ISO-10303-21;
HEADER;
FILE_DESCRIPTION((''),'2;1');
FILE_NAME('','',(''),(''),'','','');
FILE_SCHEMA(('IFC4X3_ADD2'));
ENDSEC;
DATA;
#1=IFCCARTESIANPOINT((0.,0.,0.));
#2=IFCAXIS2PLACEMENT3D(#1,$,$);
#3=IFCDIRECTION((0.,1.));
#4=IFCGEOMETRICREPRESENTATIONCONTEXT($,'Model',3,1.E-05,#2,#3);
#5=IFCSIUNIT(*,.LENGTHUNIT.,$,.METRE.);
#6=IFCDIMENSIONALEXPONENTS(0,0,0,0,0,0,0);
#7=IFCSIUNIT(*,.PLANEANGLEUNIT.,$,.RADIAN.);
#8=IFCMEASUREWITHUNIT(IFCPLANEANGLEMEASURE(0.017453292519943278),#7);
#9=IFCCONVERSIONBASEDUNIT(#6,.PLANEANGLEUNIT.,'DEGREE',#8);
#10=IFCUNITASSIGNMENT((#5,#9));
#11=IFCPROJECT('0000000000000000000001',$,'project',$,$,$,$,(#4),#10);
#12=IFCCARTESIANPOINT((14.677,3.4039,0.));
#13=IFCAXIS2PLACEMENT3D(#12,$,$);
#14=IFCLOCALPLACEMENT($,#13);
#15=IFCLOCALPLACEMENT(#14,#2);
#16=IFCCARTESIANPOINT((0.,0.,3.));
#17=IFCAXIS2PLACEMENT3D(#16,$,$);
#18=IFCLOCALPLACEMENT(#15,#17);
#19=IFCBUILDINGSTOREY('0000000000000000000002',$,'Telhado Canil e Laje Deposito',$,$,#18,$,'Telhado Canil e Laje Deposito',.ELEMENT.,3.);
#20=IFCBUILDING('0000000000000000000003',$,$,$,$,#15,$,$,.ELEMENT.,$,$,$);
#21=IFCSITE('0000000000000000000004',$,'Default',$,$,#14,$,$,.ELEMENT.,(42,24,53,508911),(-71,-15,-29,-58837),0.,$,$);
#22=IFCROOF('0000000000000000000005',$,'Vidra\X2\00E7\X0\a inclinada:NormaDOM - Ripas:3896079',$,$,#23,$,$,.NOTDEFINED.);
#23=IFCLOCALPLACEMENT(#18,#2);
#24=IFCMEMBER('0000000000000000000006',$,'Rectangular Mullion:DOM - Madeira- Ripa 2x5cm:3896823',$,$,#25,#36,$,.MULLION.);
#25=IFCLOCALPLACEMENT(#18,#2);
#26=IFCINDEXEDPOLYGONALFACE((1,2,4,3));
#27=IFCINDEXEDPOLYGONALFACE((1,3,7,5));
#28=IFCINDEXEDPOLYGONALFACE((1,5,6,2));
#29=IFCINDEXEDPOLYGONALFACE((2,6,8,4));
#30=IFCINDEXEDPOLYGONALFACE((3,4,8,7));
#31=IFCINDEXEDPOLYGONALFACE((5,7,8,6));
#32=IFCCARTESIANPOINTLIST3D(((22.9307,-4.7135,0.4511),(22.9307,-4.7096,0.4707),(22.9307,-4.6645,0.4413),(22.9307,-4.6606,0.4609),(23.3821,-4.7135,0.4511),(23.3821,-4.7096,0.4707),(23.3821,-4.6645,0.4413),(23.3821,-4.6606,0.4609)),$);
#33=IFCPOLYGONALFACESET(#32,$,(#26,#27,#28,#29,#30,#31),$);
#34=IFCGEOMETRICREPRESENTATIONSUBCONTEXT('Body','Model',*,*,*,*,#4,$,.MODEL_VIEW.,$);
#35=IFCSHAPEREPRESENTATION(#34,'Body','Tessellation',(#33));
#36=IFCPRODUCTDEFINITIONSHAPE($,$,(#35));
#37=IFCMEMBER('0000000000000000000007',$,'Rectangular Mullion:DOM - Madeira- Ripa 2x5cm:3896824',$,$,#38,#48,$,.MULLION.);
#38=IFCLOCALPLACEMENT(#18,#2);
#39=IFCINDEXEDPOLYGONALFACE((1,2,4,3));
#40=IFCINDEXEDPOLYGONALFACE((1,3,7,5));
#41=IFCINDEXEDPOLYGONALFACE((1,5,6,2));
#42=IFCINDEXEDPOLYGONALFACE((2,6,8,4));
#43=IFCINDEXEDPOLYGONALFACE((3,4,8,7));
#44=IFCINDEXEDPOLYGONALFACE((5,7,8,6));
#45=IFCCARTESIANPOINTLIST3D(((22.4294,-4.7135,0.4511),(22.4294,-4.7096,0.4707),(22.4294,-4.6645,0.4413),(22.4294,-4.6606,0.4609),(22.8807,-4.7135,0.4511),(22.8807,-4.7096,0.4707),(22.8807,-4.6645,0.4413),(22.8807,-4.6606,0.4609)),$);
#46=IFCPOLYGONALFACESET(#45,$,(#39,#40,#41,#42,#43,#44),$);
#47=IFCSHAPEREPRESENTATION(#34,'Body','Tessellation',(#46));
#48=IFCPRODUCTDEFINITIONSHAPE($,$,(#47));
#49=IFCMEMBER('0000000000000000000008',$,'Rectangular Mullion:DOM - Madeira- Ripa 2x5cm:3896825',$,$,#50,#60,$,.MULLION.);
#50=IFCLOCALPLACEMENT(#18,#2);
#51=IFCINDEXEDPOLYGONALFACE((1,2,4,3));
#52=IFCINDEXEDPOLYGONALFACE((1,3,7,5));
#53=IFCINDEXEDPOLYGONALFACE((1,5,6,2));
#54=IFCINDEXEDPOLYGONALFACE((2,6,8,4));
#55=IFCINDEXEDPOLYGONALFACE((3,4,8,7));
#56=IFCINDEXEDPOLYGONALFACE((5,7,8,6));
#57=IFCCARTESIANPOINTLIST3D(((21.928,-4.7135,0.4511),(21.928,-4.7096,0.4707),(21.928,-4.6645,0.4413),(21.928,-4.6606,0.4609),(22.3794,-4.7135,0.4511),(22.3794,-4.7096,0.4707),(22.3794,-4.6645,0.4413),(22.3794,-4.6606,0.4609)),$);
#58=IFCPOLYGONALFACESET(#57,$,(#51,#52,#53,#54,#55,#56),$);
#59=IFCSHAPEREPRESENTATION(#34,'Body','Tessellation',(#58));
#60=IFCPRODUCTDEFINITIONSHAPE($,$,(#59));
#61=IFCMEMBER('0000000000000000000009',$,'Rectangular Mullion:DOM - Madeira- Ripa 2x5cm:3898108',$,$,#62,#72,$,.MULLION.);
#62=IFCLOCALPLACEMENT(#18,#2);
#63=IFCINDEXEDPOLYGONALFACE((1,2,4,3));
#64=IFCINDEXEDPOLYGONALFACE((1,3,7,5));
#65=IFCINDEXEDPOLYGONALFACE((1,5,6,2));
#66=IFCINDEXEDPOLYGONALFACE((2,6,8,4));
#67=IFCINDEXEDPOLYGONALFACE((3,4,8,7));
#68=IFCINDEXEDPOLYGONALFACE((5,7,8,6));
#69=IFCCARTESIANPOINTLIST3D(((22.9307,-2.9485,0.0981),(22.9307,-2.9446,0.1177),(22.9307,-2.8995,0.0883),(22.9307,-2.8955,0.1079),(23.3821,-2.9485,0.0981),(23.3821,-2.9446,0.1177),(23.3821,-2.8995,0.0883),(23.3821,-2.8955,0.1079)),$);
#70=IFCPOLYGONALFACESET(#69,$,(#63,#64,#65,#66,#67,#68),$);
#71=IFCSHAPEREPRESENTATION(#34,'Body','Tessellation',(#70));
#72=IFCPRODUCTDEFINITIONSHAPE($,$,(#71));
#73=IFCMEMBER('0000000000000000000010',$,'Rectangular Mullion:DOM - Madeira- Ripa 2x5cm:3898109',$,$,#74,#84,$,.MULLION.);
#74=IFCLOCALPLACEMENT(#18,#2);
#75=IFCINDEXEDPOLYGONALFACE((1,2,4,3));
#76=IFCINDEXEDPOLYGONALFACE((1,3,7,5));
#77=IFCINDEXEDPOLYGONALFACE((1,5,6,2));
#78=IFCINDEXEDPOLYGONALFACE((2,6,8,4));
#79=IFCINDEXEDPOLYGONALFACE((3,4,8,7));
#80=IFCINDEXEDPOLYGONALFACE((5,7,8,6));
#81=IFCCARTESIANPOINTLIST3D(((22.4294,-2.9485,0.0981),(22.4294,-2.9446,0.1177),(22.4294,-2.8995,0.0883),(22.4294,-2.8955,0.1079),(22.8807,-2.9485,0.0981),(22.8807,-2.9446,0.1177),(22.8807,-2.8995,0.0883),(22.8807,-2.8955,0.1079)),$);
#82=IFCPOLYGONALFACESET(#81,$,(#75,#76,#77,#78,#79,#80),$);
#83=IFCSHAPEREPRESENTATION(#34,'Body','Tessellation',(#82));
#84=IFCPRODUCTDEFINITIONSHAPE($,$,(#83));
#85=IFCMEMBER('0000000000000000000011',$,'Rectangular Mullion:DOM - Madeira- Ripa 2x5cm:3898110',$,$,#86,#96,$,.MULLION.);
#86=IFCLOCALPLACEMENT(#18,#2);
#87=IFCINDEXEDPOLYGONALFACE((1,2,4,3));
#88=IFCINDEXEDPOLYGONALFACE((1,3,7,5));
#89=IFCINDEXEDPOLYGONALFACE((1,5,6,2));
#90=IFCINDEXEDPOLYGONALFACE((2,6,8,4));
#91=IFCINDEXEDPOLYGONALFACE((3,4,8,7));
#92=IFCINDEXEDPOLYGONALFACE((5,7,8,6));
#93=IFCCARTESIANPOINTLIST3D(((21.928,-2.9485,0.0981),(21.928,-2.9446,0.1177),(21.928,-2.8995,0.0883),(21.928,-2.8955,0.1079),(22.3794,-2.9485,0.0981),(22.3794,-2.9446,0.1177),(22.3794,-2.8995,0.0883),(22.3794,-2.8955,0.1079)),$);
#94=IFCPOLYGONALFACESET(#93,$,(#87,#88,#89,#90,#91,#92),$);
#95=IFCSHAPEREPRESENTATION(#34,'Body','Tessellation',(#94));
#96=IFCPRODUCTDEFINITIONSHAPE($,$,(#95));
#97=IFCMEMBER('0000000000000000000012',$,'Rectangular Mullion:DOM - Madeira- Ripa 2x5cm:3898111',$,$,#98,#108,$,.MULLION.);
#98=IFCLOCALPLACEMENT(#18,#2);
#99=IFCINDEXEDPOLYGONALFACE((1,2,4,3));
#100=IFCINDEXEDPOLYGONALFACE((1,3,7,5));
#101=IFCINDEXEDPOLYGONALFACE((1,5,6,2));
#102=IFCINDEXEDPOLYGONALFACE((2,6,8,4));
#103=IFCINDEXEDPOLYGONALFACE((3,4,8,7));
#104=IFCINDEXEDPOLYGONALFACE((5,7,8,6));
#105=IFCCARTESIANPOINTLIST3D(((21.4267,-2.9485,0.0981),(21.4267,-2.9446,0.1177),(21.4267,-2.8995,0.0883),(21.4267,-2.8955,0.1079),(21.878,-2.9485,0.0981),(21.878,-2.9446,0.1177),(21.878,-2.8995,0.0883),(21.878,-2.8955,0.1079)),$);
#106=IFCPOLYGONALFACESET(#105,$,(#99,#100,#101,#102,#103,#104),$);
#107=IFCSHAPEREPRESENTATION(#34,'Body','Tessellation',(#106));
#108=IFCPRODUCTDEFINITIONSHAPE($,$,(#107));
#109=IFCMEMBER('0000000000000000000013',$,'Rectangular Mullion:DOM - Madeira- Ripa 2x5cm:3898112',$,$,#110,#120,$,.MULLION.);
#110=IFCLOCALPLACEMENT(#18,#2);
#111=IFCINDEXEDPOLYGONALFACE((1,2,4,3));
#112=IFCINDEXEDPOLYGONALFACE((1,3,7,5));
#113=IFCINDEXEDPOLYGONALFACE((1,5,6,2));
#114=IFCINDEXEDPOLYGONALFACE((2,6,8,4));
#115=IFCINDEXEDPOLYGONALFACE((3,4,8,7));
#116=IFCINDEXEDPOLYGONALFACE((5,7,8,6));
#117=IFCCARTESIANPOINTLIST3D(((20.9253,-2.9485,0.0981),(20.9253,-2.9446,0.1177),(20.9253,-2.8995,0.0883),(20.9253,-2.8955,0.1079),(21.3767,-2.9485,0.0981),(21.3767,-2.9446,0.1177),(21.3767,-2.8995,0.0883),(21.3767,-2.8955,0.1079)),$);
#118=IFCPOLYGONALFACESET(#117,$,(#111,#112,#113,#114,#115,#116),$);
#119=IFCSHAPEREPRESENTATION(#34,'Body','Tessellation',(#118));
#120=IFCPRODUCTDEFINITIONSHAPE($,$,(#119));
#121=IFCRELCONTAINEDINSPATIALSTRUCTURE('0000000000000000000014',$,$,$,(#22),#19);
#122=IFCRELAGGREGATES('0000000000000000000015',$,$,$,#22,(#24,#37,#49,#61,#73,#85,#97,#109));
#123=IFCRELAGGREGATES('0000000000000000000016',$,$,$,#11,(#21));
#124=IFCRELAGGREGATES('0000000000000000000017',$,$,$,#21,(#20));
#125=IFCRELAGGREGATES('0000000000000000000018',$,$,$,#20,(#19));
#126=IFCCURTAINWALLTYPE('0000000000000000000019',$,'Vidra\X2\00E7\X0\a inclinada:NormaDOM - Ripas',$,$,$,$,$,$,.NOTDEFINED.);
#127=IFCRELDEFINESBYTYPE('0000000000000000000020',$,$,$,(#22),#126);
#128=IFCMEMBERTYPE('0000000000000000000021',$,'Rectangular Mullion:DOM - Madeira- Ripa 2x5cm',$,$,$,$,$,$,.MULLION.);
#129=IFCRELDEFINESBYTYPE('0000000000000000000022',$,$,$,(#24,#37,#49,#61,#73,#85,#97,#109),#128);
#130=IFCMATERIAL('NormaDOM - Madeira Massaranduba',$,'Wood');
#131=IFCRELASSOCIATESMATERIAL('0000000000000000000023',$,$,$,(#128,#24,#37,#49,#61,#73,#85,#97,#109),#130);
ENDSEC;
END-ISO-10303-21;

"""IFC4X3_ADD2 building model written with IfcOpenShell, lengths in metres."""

from ifc_helpers import new_model, entity, si_unit, converted_unit, direction, frame, origin, origin_2d_with_axis, place, context, subcontext, project, spatial, rectangle, extrude, source, transform, mapped, material, material_profile, profile_set, profile_usage, type_object, type_shapes, element, aggregate, save


model = new_model("IFC4X3_ADD2")

# Units and contexts
model_context = context("Model", 3, precision=1e-05, world=origin(), true_north=direction((0.0, 1.0)))
body_context = subcontext(model_context, "Body", "Model", "MODEL_VIEW")
ifc_project = project(units=[si_unit("LENGTHUNIT", "METRE"), converted_unit("PLANEANGLEUNIT", "DEGREE", entity("IfcPlaneAngleMeasure", 0.017453292519943278), si_unit("PLANEANGLEUNIT", "RADIAN"), dimensions=[0, 0, 0, 0, 0, 0, 0])], contexts=[model_context])

# Site, building, storey
site_placement = place(None, frame((14.677, 3.4039, 0.0)))
site = spatial("IfcSite", under=ifc_project, at=site_placement, Name="Default", CompositionType="ELEMENT", RefLatitude=(42, 24, 53, 508911), RefLongitude=(-71, -15, -29, -58837), RefElevation=0.0)
building_placement = place(site_placement, origin())
building = spatial("IfcBuilding", under=site, at=building_placement, CompositionType="ELEMENT")
storey_placement = place(building_placement, frame((0.0, 0.0, 3.0)))
storey = spatial("IfcBuildingStorey", under=building, at=storey_placement, Name="Telhado Canil e Laje Deposito", LongName="Telhado Canil e Laje Deposito", CompositionType="ELEMENT", Elevation=3.0)

# Roof
ifc_material = material(Name="NormaDOM - Madeira Massaranduba", Category="Wood")
ifc_material_profile_1 = material_profile(ifc_material, rectangle(XDim=0.05, YDim=0.02, at=origin_2d_with_axis()), Name="DOM - Madeira- Ripa 2x5cm")
ifc_profile_set_1 = profile_set([ifc_material_profile_1], Name="DOM - Madeira- Ripa 2x5cm")
ifc_profile_usage_1 = profile_usage(ifc_profile_set_1)
curtain_wall_type_1 = type_object("IfcCurtainWallType", Name="Vidraça inclinada:NormaDOM - Ripas", PredefinedType="NOTDEFINED")
roof_1_placement = place(storey_placement, frame((0.0, 0.0, -3.0)))
roof_1 = element("IfcRoof", 1, at=roof_1_placement, inside=storey, type_object=curtain_wall_type_1, Name="Vidraça inclinada:NormaDOM - Ripas:3896079", PredefinedType="NOTDEFINED")

# Members
member_type_1 = type_object("IfcMemberType", Name="Rectangular Mullion:DOM - Madeira- Ripa 2x5cm", PredefinedType="MULLION", material=ifc_profile_set_1)
shared_shape_1 = source(origin(), body_context, "Body", "SweptSolid", [
    extrude(rectangle(XDim=0.05, YDim=0.02, at=origin_2d_with_axis()), frame((0.025, 0.01, -0.4514), z_axis=(0.0, 0.0, 1.0), x_axis=(-1.0, 0.0, 0.0)), (0.0, 0.0, 1.0), 0.4514),
])
type_shapes(member_type_1, [shared_shape_1])
member_1_placement = place(roof_1_placement, frame((23.3821, -4.6606, 3.4609), z_axis=(1.0, 0.0, 0.0), x_axis=(0.0, -0.980581, 0.196116)))
member_1 = element("IfcMember", 2, at=member_1_placement, type_object=member_type_1, material=ifc_profile_usage_1, Name="Rectangular Mullion:DOM - Madeira- Ripa 2x5cm:3896823", PredefinedType="MULLION", context=body_context, shape_type="MappedRepresentation", body=[
    mapped(shared_shape_1, transform((0.0, 0.0, 0.0), scale=1.0)),
])
member_2_placement = place(roof_1_placement, frame((22.8807, -4.6606, 3.4609), z_axis=(1.0, 0.0, 0.0), x_axis=(0.0, -0.980581, 0.196116)))
member_2 = element("IfcMember", 3, at=member_2_placement, type_object=member_type_1, material=ifc_profile_usage_1, Name="Rectangular Mullion:DOM - Madeira- Ripa 2x5cm:3896824", PredefinedType="MULLION", context=body_context, shape_type="MappedRepresentation", body=[
    mapped(shared_shape_1, transform((0.0, 0.0, 0.0), scale=1.0)),
])
member_3_placement = place(roof_1_placement, frame((22.3794, -4.6606, 3.4609), z_axis=(1.0, 0.0, 0.0), x_axis=(0.0, -0.980581, 0.196116)))
member_3 = element("IfcMember", 4, at=member_3_placement, type_object=member_type_1, material=ifc_profile_usage_1, Name="Rectangular Mullion:DOM - Madeira- Ripa 2x5cm:3896825", PredefinedType="MULLION", context=body_context, shape_type="MappedRepresentation", body=[
    mapped(shared_shape_1, transform((0.0, 0.0, 0.0), scale=1.0)),
])
member_4_placement = place(roof_1_placement, frame((23.3821, -2.8955, 3.1079), z_axis=(1.0, 0.0, 0.0), x_axis=(0.0, -0.980581, 0.196116)))
member_4 = element("IfcMember", 5, at=member_4_placement, type_object=member_type_1, material=ifc_profile_usage_1, Name="Rectangular Mullion:DOM - Madeira- Ripa 2x5cm:3898108", PredefinedType="MULLION", context=body_context, shape_type="MappedRepresentation", body=[
    mapped(shared_shape_1, transform((0.0, 0.0, 0.0), scale=1.0)),
])
member_5_placement = place(roof_1_placement, frame((22.8807, -2.8955, 3.1079), z_axis=(1.0, 0.0, 0.0), x_axis=(0.0, -0.980581, 0.196116)))
member_5 = element("IfcMember", 6, at=member_5_placement, type_object=member_type_1, material=ifc_profile_usage_1, Name="Rectangular Mullion:DOM - Madeira- Ripa 2x5cm:3898109", PredefinedType="MULLION", context=body_context, shape_type="MappedRepresentation", body=[
    mapped(shared_shape_1, transform((0.0, 0.0, 0.0), scale=1.0)),
])
member_6_placement = place(roof_1_placement, frame((22.3794, -2.8955, 3.1079), z_axis=(1.0, 0.0, 0.0), x_axis=(0.0, -0.980581, 0.196116)))
member_6 = element("IfcMember", 7, at=member_6_placement, type_object=member_type_1, material=ifc_profile_usage_1, Name="Rectangular Mullion:DOM - Madeira- Ripa 2x5cm:3898110", PredefinedType="MULLION", context=body_context, shape_type="MappedRepresentation", body=[
    mapped(shared_shape_1, transform((0.0, 0.0, 0.0), scale=1.0)),
])
member_7_placement = place(roof_1_placement, frame((21.878, -2.8955, 3.1079), z_axis=(1.0, 0.0, 0.0), x_axis=(0.0, -0.980581, 0.196116)))
member_7 = element("IfcMember", 8, at=member_7_placement, type_object=member_type_1, material=ifc_profile_usage_1, Name="Rectangular Mullion:DOM - Madeira- Ripa 2x5cm:3898111", PredefinedType="MULLION", context=body_context, shape_type="MappedRepresentation", body=[
    mapped(shared_shape_1, transform((0.0, 0.0, 0.0), scale=1.0)),
])
member_8_placement = place(roof_1_placement, frame((21.3767, -2.8955, 3.1079), z_axis=(1.0, 0.0, 0.0), x_axis=(0.0, -0.980581, 0.196116)))
member_8 = element("IfcMember", 9, at=member_8_placement, type_object=member_type_1, material=ifc_profile_usage_1, Name="Rectangular Mullion:DOM - Madeira- Ripa 2x5cm:3898112", PredefinedType="MULLION", context=body_context, shape_type="MappedRepresentation", body=[
    mapped(shared_shape_1, transform((0.0, 0.0, 0.0), scale=1.0)),
])
aggregate(roof_1, [member_1, member_2, member_3, member_4, member_5, member_6, member_7, member_8])

save(model, "model.ifc")
